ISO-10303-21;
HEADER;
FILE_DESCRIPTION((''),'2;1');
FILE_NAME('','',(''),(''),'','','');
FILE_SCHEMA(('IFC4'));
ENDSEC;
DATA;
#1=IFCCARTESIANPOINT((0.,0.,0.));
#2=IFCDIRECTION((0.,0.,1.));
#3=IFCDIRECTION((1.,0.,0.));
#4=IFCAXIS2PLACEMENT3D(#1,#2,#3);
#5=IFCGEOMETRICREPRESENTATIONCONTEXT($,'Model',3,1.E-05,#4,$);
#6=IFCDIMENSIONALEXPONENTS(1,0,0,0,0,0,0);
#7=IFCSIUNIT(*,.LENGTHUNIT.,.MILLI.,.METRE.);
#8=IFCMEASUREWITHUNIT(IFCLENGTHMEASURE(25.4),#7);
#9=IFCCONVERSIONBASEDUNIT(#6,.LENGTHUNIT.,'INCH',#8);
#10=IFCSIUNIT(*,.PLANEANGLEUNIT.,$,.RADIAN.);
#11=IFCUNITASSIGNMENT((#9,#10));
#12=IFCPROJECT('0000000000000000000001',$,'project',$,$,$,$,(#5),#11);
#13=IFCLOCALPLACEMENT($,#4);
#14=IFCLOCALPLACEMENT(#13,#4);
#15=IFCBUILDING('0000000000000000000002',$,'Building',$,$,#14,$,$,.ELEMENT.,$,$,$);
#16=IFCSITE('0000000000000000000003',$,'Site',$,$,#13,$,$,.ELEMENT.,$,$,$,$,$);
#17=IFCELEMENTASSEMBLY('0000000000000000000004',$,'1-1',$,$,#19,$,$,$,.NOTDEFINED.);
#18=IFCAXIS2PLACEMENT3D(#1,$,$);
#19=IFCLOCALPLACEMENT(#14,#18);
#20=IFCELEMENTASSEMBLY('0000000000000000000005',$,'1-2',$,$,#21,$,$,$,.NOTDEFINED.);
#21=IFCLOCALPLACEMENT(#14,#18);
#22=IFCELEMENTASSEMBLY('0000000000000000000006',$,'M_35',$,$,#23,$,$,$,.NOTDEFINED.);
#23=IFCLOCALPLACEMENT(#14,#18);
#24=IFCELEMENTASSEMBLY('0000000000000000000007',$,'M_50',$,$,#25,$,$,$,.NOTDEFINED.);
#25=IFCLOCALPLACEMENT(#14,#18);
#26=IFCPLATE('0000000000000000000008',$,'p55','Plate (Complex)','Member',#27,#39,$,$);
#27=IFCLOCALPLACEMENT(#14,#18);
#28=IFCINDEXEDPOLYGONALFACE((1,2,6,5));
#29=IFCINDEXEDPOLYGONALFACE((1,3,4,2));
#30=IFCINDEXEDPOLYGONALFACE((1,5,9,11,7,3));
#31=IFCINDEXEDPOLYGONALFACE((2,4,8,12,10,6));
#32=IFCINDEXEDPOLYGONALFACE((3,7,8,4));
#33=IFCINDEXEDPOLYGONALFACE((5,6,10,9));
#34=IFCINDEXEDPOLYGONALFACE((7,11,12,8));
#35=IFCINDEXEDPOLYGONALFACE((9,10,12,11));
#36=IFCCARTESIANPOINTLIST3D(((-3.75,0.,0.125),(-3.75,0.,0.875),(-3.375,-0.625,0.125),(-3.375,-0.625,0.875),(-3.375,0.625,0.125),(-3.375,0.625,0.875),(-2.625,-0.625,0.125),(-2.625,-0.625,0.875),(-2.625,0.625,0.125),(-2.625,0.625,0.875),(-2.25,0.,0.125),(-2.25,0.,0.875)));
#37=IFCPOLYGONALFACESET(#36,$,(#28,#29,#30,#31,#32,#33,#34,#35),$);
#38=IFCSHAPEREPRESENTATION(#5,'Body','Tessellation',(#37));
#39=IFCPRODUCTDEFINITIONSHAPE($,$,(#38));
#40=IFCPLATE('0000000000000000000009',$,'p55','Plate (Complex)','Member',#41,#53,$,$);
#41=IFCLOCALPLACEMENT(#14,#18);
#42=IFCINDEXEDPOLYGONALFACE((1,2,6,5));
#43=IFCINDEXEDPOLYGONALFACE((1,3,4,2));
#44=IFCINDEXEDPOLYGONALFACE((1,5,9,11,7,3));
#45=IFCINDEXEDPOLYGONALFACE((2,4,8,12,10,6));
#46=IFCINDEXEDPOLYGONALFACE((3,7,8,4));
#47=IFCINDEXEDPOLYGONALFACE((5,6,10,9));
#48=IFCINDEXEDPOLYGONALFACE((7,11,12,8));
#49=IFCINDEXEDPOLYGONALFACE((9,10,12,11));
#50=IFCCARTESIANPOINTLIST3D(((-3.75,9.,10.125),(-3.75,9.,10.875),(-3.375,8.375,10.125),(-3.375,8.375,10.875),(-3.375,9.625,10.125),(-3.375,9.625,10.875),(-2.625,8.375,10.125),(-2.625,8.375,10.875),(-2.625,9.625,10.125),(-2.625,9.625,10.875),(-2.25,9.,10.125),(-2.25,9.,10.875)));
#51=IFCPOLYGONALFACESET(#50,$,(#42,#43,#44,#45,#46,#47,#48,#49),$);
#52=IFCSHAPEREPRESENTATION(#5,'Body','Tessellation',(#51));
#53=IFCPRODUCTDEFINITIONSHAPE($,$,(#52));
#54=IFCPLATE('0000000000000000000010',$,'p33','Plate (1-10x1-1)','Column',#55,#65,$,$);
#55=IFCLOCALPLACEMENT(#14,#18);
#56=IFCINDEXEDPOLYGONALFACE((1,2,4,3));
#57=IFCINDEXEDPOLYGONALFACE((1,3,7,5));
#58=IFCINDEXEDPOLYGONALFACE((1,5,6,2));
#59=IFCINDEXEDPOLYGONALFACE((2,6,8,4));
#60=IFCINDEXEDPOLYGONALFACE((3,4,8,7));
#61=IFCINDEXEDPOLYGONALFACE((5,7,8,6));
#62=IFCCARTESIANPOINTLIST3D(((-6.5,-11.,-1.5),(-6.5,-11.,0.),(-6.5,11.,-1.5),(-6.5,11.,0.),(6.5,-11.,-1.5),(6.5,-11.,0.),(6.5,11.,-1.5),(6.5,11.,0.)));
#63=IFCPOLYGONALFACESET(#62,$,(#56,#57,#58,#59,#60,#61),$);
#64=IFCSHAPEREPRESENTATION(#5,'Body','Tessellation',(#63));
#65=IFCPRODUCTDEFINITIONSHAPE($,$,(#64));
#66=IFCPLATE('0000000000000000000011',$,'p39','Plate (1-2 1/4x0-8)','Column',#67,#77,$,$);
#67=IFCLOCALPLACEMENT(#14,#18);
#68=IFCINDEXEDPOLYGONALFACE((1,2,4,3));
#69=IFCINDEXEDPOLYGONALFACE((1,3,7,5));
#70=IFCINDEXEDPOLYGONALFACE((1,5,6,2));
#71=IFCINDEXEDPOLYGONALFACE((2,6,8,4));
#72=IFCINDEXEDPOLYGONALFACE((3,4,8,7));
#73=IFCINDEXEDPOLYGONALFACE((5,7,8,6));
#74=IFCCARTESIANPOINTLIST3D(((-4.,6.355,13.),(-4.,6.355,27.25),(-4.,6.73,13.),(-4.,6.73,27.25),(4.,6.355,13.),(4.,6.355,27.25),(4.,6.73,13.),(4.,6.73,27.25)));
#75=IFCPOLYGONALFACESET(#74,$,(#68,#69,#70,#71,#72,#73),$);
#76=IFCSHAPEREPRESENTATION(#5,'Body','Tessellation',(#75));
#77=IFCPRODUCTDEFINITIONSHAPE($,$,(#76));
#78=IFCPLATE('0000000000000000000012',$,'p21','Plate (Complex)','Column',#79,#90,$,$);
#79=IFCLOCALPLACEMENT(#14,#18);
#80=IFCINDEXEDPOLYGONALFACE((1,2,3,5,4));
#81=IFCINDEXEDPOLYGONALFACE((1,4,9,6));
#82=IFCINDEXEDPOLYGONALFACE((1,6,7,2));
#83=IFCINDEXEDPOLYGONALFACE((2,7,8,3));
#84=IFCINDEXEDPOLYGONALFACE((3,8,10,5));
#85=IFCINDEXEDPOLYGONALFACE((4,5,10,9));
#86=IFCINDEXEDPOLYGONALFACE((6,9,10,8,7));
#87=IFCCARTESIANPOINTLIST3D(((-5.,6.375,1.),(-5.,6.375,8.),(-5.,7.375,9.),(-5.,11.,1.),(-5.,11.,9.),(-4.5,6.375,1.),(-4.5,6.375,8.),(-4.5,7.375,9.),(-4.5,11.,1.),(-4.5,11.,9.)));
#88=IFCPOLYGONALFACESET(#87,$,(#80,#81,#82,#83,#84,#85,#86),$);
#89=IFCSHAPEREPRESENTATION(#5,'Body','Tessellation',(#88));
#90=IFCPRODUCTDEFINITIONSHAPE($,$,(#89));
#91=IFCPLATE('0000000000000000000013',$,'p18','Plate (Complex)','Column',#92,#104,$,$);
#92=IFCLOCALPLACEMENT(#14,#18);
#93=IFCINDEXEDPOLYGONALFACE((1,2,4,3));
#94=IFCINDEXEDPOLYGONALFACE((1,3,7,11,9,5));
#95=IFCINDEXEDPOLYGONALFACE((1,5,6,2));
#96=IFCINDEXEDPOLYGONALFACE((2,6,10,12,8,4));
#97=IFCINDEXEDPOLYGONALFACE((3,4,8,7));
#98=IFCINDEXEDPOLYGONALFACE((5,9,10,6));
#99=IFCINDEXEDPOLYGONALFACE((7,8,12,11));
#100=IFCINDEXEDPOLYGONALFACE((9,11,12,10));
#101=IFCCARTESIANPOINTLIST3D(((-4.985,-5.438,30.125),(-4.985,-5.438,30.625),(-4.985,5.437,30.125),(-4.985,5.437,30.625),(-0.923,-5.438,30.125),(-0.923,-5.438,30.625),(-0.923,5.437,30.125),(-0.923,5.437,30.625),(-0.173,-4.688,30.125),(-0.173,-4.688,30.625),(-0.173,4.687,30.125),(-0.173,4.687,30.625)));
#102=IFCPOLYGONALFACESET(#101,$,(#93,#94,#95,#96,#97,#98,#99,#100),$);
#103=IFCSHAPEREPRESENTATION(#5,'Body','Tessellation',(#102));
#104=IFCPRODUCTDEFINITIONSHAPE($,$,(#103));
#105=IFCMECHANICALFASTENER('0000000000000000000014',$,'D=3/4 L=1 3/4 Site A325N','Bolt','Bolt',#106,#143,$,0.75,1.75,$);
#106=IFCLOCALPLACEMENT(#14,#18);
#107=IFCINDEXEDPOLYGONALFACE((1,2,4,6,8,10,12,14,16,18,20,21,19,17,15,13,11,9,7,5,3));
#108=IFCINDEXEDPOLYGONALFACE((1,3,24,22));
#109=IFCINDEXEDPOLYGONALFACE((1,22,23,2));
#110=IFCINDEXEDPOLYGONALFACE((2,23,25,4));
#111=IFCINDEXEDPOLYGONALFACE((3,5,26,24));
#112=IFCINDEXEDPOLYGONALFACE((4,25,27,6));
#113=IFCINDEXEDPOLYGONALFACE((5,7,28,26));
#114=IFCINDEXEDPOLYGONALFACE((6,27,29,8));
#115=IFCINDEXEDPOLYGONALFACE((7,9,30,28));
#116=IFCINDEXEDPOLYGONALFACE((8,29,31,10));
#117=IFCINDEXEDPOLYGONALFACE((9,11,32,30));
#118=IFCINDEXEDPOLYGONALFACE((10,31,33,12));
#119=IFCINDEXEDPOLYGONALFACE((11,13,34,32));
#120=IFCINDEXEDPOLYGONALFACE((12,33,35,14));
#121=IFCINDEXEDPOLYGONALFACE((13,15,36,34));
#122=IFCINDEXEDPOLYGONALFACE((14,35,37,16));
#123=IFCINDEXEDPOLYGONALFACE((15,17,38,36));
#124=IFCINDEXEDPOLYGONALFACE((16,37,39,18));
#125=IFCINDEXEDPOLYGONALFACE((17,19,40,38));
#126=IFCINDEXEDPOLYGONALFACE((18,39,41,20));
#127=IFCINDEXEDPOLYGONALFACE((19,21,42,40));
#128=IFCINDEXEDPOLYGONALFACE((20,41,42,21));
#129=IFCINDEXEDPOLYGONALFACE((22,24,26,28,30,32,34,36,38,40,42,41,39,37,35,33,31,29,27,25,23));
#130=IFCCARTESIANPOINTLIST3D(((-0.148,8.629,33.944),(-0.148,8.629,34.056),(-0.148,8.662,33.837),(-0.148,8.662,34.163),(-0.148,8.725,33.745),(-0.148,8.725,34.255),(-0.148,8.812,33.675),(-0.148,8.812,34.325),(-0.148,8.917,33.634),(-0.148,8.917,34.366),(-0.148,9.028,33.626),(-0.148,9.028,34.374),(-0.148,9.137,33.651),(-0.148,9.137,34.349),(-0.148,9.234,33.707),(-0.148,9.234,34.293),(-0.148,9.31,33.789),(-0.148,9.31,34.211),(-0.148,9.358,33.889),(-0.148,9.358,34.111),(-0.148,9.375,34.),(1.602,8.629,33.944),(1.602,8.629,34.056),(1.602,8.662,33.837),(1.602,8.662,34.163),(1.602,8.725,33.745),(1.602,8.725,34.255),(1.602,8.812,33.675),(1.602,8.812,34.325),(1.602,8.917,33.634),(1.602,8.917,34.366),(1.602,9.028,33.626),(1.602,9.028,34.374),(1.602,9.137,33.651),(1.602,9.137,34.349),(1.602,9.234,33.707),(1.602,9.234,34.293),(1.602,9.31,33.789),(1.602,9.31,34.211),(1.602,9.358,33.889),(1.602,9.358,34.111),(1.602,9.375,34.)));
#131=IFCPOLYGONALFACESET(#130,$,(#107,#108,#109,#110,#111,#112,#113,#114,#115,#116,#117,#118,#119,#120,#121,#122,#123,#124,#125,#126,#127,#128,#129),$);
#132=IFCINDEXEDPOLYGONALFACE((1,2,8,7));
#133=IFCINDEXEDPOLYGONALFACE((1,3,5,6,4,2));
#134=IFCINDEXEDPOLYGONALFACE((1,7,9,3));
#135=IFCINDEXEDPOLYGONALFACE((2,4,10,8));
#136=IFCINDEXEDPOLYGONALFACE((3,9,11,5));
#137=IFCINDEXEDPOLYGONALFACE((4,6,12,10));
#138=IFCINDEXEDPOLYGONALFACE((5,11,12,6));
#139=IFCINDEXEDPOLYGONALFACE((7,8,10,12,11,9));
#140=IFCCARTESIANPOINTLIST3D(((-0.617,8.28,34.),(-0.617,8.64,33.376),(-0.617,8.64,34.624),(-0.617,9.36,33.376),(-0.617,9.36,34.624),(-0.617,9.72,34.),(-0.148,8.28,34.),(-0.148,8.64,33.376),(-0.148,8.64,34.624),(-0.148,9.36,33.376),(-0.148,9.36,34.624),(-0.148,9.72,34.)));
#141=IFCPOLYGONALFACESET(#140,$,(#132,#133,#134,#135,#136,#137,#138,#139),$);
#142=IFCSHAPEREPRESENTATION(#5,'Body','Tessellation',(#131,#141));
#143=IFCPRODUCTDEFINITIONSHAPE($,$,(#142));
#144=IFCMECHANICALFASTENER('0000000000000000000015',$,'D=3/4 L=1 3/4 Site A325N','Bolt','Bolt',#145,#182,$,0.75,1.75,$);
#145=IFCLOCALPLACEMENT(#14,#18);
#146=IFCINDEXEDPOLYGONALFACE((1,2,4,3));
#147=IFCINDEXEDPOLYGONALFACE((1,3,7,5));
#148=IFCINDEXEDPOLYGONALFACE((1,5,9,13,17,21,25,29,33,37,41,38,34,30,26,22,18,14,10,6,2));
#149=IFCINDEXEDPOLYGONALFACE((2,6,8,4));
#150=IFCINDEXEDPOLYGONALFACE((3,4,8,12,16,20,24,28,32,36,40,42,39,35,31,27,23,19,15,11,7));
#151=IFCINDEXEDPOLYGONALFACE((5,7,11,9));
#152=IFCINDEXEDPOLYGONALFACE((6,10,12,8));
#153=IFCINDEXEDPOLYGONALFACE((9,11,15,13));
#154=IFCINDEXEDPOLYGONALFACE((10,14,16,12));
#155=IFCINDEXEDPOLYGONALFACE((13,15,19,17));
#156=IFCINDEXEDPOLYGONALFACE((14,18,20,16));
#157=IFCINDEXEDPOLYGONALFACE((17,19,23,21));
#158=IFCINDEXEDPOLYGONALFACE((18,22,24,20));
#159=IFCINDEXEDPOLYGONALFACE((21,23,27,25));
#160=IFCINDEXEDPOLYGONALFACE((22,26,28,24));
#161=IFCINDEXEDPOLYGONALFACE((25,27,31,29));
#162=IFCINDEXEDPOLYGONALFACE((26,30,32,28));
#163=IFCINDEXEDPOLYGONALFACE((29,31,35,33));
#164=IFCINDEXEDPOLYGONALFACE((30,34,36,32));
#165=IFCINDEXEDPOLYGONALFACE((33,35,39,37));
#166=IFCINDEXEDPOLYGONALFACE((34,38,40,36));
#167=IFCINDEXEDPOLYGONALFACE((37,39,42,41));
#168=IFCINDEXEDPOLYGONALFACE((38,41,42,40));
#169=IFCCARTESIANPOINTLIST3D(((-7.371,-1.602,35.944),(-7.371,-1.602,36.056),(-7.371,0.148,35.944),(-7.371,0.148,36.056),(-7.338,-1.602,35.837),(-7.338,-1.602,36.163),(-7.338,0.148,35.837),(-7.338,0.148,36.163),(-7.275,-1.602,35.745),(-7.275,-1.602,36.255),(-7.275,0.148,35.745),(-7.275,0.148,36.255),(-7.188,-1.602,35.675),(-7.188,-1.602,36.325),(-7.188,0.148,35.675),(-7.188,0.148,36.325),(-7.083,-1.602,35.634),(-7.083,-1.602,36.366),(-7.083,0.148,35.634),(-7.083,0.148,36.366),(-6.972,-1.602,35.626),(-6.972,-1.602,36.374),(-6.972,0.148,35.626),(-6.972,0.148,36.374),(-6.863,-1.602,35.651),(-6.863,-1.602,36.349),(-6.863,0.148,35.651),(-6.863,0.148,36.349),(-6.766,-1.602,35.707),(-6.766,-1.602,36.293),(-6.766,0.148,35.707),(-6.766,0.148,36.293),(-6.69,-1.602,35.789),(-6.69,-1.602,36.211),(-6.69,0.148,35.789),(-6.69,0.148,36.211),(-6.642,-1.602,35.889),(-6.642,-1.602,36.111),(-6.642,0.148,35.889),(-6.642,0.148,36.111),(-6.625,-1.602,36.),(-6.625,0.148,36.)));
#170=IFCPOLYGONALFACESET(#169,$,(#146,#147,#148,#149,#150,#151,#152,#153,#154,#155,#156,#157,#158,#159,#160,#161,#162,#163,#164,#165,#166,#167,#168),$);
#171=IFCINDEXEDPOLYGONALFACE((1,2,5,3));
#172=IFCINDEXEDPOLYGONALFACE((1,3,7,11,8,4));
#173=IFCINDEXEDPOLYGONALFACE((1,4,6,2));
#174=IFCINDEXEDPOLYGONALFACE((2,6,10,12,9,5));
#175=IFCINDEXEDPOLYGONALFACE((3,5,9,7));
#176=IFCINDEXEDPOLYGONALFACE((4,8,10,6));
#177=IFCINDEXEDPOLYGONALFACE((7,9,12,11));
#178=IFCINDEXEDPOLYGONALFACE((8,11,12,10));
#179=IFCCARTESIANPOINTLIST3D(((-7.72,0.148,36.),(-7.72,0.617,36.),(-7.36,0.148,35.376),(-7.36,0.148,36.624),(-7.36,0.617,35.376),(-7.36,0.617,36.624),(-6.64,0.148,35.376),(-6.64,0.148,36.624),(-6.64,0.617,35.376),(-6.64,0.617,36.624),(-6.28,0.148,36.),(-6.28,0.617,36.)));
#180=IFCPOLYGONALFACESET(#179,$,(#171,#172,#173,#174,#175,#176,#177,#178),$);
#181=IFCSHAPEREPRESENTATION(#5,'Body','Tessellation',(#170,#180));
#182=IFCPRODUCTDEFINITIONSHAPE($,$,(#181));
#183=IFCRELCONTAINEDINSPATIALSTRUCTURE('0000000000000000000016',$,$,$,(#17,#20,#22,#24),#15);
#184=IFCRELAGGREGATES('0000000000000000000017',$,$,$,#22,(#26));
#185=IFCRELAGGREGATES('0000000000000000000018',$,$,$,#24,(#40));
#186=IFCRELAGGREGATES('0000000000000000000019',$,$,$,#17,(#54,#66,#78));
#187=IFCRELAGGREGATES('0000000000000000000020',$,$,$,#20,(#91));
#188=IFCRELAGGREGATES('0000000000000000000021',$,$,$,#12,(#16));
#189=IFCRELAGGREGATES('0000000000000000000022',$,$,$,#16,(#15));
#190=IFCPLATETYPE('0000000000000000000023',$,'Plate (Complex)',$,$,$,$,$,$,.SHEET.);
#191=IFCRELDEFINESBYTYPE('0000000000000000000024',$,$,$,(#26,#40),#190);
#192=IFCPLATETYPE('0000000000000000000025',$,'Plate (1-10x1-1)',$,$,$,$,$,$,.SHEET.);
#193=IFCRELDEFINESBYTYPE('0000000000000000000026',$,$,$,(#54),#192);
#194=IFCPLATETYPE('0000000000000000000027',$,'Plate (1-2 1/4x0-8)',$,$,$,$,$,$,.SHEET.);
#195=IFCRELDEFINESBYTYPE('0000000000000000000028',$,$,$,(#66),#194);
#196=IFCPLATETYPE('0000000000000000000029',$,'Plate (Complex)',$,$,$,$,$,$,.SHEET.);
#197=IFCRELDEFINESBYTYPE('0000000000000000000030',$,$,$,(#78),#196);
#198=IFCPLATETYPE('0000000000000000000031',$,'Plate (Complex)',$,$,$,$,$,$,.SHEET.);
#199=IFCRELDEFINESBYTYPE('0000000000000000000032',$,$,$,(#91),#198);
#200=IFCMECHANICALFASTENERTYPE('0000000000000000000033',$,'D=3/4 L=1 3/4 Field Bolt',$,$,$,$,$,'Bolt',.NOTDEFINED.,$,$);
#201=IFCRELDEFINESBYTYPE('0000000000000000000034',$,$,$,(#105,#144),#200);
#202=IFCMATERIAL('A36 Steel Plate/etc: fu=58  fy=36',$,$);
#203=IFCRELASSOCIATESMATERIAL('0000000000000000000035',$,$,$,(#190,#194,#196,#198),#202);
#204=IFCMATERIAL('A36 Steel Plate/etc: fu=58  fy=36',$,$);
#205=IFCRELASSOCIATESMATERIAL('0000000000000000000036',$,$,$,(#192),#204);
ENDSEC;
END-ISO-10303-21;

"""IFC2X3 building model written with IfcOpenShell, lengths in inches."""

from ifc_helpers import new_model, entity, si_unit, converted_unit, frame, origin_with_axes, origin_2d_with_axis, place, context, project, spatial, polyline, circle, outline, extrude, source, transform, mapped, material, type_object, type_shapes, element, aggregate, save


model = new_model("IFC2X3")

# Units and contexts
model_context = context("Model", 3, precision=1e-05, world=origin_with_axes())
ifc_project = project(units=[converted_unit("LENGTHUNIT", "INCH", entity("IfcLengthMeasure", 25.4), si_unit("LENGTHUNIT", "METRE", prefix="MILLI"), dimensions=[1, 0, 0, 0, 0, 0, 0]), si_unit("PLANEANGLEUNIT", "RADIAN")], contexts=[model_context])

# Site, building
site_placement = place(None, origin_with_axes())
site = spatial("IfcSite", under=ifc_project, at=site_placement, Name="Site", CompositionType="ELEMENT")
building_placement = place(site_placement, origin_with_axes())
building = spatial("IfcBuilding", under=site, at=building_placement, Name="Building", CompositionType="ELEMENT")

# Element assemblies
assembly_1_placement = place(building_placement, frame((0.0, 0.0, -1.5), z_axis=(0.0, -1.0, 0.0), x_axis=(0.0, 0.0, 1.0)))
assembly_1 = element("IfcElementAssembly", 1, at=assembly_1_placement, inside=building, Name="1-1", PredefinedType="NOTDEFINED")
assembly_2_placement = place(building_placement, frame((0.0, 0.0, 21.0), z_axis=(0.0, -1.0, 0.0), x_axis=(0.0, 0.0, 1.0)))
assembly_2 = element("IfcElementAssembly", 2, at=assembly_2_placement, inside=building, Name="1-2", PredefinedType="NOTDEFINED")
assembly_3_placement = place(building_placement, frame((-3.0, 0.0, -22.668), z_axis=(0.0, -1.0, 0.0), x_axis=(0.0, 0.0, 1.0)))
assembly_3 = element("IfcElementAssembly", 3, at=assembly_3_placement, inside=building, Name="M_35", PredefinedType="NOTDEFINED")
assembly_4_placement = place(building_placement, frame((-3.0, 9.0, -22.668), z_axis=(0.0, -1.0, 0.0), x_axis=(0.0, 0.0, 1.0)))
assembly_4 = element("IfcElementAssembly", 4, at=assembly_4_placement, inside=building, Name="M_50", PredefinedType="NOTDEFINED")

# Shared definitions
assembly_5_placement = place(building_placement, frame((0.0, 0.0, 46.0), z_axis=(0.0, 0.0, 1.0), x_axis=(0.0, 1.0, 0.0)))

# Shared definitions
ifc_material_1 = material(Name="A36 Steel Plate/etc: fu=58  fy=36")

# Plates
plate_type_1 = type_object("IfcPlateType", Name="Plate (Complex)", PredefinedType="SHEET", material=ifc_material_1)
shared_shape_1 = source(origin_with_axes(), model_context, "Body", "SweptSolid", [
    extrude(outline(polyline([(0.0, -1.125), (-0.625, -1.5), (-1.25, -1.125), (-1.25, -0.375), (-0.625, 0.0), (0.0, -0.375), (0.0, -1.125)])), frame((-0.375, 0.0, 0.0), z_axis=(1.0, 0.0, 0.0), x_axis=(0.0, 1.0, 0.0)), (0.0, 0.0, 1.0), 0.75),
])
type_shapes(plate_type_1, [shared_shape_1])
plate_1_placement = place(assembly_3_placement, frame((23.168, 0.75, -0.625), z_axis=(0.0, 1.0, 0.0), x_axis=(1.0, 0.0, 0.0)))
plate_1 = element("IfcPlate", 5, at=plate_1_placement, type_object=plate_type_1, Name="p55", Description="Plate (Complex)", ObjectType="Member", context=model_context, shape_type="MappedRepresentation", body=[
    mapped(shared_shape_1, transform((0.0, 0.0, 0.0), scale=1.0)),
])
aggregate(assembly_3, [plate_1])
plate_2_placement = place(assembly_4_placement, frame((33.168, 0.75, -0.625), z_axis=(0.0, 1.0, 0.0), x_axis=(1.0, 0.0, 0.0)))
plate_2 = element("IfcPlate", 6, at=plate_2_placement, type_object=plate_type_1, Name="p55", Description="Plate (Complex)", ObjectType="Member", context=model_context, shape_type="MappedRepresentation", body=[
    mapped(shared_shape_1, transform((0.0, 0.0, 0.0), scale=1.0)),
])
aggregate(assembly_4, [plate_2])
ifc_material_2 = material(Name="A36 Steel Plate/etc: fu=58  fy=36")
plate_type_2 = type_object("IfcPlateType", Name="Plate (1-10x1-1)", PredefinedType="SHEET", material=ifc_material_2)
shared_shape_2 = source(origin_with_axes(), model_context, "Body", "SweptSolid", [
    extrude(outline(polyline([(6.5, -11.0), (-6.5, -11.0), (-6.5, 11.0), (6.5, 11.0), (6.5, -11.0)])), frame((-0.75, 0.0, 0.0), z_axis=(1.0, 0.0, 0.0), x_axis=(0.0, 1.0, 0.0)), (0.0, 0.0, 1.0), 1.5),
])
type_shapes(plate_type_2, [shared_shape_2])
plate_3_placement = place(assembly_1_placement, frame((0.75, 0.0, 0.0), z_axis=(0.0, 0.0, -1.0), x_axis=(1.0, 0.0, 0.0)))
plate_3 = element("IfcPlate", 7, at=plate_3_placement, type_object=plate_type_2, Name="p33", Description="Plate (1-10x1-1)", ObjectType="Column", context=model_context, shape_type="MappedRepresentation", body=[
    mapped(shared_shape_2, transform((0.0, 0.0, 0.0), scale=1.0)),
])
plate_type_3 = type_object("IfcPlateType", Name="Plate (1-2 1/4x0-8)", PredefinedType="SHEET", material=ifc_material_1)
shared_shape_3 = source(origin_with_axes(), model_context, "Body", "SweptSolid", [
    extrude(outline(polyline([(4.0, -14.25), (-4.0, -14.25), (-4.0, 0.0), (4.0, 0.0), (4.0, -14.25)])), frame((-0.188, 0.0, 0.0), z_axis=(1.0, 0.0, 0.0), x_axis=(0.0, 1.0, 0.0)), (0.0, 0.0, 1.0), 0.375),
])
type_shapes(plate_type_3, [shared_shape_3])
plate_4_placement = place(assembly_1_placement, frame((14.5, 0.0, -6.543), z_axis=(-1.0, 0.0, 0.0), x_axis=(0.0, 0.0, -1.0)))
plate_4 = element("IfcPlate", 8, at=plate_4_placement, type_object=plate_type_3, Name="p39", Description="Plate (1-2 1/4x0-8)", ObjectType="Column", context=model_context, shape_type="MappedRepresentation", body=[
    mapped(shared_shape_3, transform((0.0, 0.0, 0.0), scale=1.0)),
])
plate_type_4 = type_object("IfcPlateType", Name="Plate (Complex)", PredefinedType="SHEET", material=ifc_material_1)
shared_shape_4 = source(origin_with_axes(), model_context, "Body", "SweptSolid", [
    extrude(outline(polyline([(0.0, -8.0), (-3.625, -8.0), (-4.625, -7.0), (-4.625, 0.0), (0.0, 0.0), (0.0, -8.0)])), frame((-0.25, 0.0, 0.0), z_axis=(1.0, 0.0, 0.0), x_axis=(0.0, 1.0, 0.0)), (0.0, 0.0, 1.0), 0.5),
])
type_shapes(plate_type_4, [shared_shape_4])
plate_5_placement = place(assembly_1_placement, frame((2.5, 4.75, -11.0), z_axis=(-1.0, 0.0, 0.0), x_axis=(0.0, 1.0, 0.0)))
plate_5 = element("IfcPlate", 9, at=plate_5_placement, type_object=plate_type_4, Name="p21", Description="Plate (Complex)", ObjectType="Column", context=model_context, shape_type="MappedRepresentation", body=[
    mapped(shared_shape_4, transform((0.0, 0.0, 0.0), scale=1.0)),
])
aggregate(assembly_1, [plate_3, plate_4, plate_5])
plate_type_5 = type_object("IfcPlateType", Name="Plate (Complex)", PredefinedType="SHEET", material=ifc_material_1)
shared_shape_5 = source(origin_with_axes(), model_context, "Body", "SweptSolid", [
    extrude(outline(polyline([(5.438, -4.812), (-5.438, -4.812), (-5.438, -0.75), (-4.688, 0.0), (4.688, 0.0), (5.438, -0.75), (5.438, -4.812)])), frame((-0.25, 0.0, 0.0), z_axis=(1.0, 0.0, 0.0), x_axis=(0.0, 1.0, 0.0)), (0.0, 0.0, 1.0), 0.5),
])
type_shapes(plate_type_5, [shared_shape_5])
plate_6_placement = place(assembly_2_placement, frame((9.375, 0.173, 0.0), z_axis=(0.0, -1.0, 0.0), x_axis=(1.0, 0.0, 0.0)))
plate_6 = element("IfcPlate", 10, at=plate_6_placement, type_object=plate_type_5, Name="p18", Description="Plate (Complex)", ObjectType="Column", context=model_context, shape_type="MappedRepresentation", body=[
    mapped(shared_shape_5, transform((0.0, 0.0, 0.0), scale=1.0)),
])
aggregate(assembly_2, [plate_6])

# Mechanical fasteners
mechanical_fastener_type_1 = type_object("IfcMechanicalFastenerType", Name="D=3/4 L=1 3/4 Field Bolt", ElementType="Bolt")
shared_shape_6 = source(origin_with_axes(), model_context, "Body", "SweptSolid", [
    extrude(circle(Radius=0.375, at=origin_2d_with_axis()), frame((0.0, 0.0, 0.0), z_axis=(1.0, 0.0, 0.0), x_axis=(0.0, 1.0, 0.0)), (0.0, 0.0, 1.0), 1.75),
    extrude(outline(polyline([(-0.72, 0.0), (-0.36, 0.624), (0.36, 0.624), (0.72, 0.0), (0.36, -0.624), (-0.36, -0.624), (-0.72, 0.0)])), frame((0.0, 0.0, 0.0), z_axis=(1.0, 0.0, 0.0), x_axis=(0.0, 1.0, 0.0)), (0.0, 0.0, -1.0), 0.47),
])
type_shapes(mechanical_fastener_type_1, [shared_shape_6])
placement_1 = place(assembly_5_placement, frame((9.0, 0.148, -4.0), z_axis=(0.0, 0.0, 1.0), x_axis=(0.0, -1.0, 0.0)))
mechanical_fastener_1_placement = place(placement_1, frame((0.0, 0.0, -8.0), z_axis=(0.0, 0.0, 1.0), x_axis=(1.0, 0.0, 0.0)))
element("IfcMechanicalFastener", 11, at=mechanical_fastener_1_placement, type_object=mechanical_fastener_type_1, Name="D=3/4 L=1 3/4 Site A325N", Description="Bolt", ObjectType="Bolt", NominalDiameter=0.75, NominalLength=1.75, context=model_context, shape_type="MappedRepresentation", body=[
    mapped(shared_shape_6, transform((0.0, 0.0, 0.0), scale=1.0)),
])
placement_2 = place(building_placement, frame((0.0, 0.0, 46.0), z_axis=(0.0, 0.0, 1.0), x_axis=(-1.0, 0.0, 0.0)))
placement_3 = place(placement_2, frame((7.0, -0.148, -4.0), z_axis=(0.0, 0.0, 1.0), x_axis=(0.0, 1.0, 0.0)))
for number, where, z_axis, x_axis, name in (
    (12, (0.0, 0.0, -6.0), (0.0, 0.0, 1.0), (1.0, 0.0, 0.0), "D=3/4 L=1 3/4 Site A325N"),
):
    element("IfcMechanicalFastener", number, at=place(placement_3, frame(where, z_axis=z_axis, x_axis=x_axis)), type_object=mechanical_fastener_type_1, Name=name, Description="Bolt", ObjectType="Bolt", NominalDiameter=0.75, NominalLength=1.75, context=model_context, shape_type="MappedRepresentation", body=[
        mapped(shared_shape_6, transform((0.0, 0.0, 0.0), scale=1.0)),
    ])

save(model, "model.ifc")
